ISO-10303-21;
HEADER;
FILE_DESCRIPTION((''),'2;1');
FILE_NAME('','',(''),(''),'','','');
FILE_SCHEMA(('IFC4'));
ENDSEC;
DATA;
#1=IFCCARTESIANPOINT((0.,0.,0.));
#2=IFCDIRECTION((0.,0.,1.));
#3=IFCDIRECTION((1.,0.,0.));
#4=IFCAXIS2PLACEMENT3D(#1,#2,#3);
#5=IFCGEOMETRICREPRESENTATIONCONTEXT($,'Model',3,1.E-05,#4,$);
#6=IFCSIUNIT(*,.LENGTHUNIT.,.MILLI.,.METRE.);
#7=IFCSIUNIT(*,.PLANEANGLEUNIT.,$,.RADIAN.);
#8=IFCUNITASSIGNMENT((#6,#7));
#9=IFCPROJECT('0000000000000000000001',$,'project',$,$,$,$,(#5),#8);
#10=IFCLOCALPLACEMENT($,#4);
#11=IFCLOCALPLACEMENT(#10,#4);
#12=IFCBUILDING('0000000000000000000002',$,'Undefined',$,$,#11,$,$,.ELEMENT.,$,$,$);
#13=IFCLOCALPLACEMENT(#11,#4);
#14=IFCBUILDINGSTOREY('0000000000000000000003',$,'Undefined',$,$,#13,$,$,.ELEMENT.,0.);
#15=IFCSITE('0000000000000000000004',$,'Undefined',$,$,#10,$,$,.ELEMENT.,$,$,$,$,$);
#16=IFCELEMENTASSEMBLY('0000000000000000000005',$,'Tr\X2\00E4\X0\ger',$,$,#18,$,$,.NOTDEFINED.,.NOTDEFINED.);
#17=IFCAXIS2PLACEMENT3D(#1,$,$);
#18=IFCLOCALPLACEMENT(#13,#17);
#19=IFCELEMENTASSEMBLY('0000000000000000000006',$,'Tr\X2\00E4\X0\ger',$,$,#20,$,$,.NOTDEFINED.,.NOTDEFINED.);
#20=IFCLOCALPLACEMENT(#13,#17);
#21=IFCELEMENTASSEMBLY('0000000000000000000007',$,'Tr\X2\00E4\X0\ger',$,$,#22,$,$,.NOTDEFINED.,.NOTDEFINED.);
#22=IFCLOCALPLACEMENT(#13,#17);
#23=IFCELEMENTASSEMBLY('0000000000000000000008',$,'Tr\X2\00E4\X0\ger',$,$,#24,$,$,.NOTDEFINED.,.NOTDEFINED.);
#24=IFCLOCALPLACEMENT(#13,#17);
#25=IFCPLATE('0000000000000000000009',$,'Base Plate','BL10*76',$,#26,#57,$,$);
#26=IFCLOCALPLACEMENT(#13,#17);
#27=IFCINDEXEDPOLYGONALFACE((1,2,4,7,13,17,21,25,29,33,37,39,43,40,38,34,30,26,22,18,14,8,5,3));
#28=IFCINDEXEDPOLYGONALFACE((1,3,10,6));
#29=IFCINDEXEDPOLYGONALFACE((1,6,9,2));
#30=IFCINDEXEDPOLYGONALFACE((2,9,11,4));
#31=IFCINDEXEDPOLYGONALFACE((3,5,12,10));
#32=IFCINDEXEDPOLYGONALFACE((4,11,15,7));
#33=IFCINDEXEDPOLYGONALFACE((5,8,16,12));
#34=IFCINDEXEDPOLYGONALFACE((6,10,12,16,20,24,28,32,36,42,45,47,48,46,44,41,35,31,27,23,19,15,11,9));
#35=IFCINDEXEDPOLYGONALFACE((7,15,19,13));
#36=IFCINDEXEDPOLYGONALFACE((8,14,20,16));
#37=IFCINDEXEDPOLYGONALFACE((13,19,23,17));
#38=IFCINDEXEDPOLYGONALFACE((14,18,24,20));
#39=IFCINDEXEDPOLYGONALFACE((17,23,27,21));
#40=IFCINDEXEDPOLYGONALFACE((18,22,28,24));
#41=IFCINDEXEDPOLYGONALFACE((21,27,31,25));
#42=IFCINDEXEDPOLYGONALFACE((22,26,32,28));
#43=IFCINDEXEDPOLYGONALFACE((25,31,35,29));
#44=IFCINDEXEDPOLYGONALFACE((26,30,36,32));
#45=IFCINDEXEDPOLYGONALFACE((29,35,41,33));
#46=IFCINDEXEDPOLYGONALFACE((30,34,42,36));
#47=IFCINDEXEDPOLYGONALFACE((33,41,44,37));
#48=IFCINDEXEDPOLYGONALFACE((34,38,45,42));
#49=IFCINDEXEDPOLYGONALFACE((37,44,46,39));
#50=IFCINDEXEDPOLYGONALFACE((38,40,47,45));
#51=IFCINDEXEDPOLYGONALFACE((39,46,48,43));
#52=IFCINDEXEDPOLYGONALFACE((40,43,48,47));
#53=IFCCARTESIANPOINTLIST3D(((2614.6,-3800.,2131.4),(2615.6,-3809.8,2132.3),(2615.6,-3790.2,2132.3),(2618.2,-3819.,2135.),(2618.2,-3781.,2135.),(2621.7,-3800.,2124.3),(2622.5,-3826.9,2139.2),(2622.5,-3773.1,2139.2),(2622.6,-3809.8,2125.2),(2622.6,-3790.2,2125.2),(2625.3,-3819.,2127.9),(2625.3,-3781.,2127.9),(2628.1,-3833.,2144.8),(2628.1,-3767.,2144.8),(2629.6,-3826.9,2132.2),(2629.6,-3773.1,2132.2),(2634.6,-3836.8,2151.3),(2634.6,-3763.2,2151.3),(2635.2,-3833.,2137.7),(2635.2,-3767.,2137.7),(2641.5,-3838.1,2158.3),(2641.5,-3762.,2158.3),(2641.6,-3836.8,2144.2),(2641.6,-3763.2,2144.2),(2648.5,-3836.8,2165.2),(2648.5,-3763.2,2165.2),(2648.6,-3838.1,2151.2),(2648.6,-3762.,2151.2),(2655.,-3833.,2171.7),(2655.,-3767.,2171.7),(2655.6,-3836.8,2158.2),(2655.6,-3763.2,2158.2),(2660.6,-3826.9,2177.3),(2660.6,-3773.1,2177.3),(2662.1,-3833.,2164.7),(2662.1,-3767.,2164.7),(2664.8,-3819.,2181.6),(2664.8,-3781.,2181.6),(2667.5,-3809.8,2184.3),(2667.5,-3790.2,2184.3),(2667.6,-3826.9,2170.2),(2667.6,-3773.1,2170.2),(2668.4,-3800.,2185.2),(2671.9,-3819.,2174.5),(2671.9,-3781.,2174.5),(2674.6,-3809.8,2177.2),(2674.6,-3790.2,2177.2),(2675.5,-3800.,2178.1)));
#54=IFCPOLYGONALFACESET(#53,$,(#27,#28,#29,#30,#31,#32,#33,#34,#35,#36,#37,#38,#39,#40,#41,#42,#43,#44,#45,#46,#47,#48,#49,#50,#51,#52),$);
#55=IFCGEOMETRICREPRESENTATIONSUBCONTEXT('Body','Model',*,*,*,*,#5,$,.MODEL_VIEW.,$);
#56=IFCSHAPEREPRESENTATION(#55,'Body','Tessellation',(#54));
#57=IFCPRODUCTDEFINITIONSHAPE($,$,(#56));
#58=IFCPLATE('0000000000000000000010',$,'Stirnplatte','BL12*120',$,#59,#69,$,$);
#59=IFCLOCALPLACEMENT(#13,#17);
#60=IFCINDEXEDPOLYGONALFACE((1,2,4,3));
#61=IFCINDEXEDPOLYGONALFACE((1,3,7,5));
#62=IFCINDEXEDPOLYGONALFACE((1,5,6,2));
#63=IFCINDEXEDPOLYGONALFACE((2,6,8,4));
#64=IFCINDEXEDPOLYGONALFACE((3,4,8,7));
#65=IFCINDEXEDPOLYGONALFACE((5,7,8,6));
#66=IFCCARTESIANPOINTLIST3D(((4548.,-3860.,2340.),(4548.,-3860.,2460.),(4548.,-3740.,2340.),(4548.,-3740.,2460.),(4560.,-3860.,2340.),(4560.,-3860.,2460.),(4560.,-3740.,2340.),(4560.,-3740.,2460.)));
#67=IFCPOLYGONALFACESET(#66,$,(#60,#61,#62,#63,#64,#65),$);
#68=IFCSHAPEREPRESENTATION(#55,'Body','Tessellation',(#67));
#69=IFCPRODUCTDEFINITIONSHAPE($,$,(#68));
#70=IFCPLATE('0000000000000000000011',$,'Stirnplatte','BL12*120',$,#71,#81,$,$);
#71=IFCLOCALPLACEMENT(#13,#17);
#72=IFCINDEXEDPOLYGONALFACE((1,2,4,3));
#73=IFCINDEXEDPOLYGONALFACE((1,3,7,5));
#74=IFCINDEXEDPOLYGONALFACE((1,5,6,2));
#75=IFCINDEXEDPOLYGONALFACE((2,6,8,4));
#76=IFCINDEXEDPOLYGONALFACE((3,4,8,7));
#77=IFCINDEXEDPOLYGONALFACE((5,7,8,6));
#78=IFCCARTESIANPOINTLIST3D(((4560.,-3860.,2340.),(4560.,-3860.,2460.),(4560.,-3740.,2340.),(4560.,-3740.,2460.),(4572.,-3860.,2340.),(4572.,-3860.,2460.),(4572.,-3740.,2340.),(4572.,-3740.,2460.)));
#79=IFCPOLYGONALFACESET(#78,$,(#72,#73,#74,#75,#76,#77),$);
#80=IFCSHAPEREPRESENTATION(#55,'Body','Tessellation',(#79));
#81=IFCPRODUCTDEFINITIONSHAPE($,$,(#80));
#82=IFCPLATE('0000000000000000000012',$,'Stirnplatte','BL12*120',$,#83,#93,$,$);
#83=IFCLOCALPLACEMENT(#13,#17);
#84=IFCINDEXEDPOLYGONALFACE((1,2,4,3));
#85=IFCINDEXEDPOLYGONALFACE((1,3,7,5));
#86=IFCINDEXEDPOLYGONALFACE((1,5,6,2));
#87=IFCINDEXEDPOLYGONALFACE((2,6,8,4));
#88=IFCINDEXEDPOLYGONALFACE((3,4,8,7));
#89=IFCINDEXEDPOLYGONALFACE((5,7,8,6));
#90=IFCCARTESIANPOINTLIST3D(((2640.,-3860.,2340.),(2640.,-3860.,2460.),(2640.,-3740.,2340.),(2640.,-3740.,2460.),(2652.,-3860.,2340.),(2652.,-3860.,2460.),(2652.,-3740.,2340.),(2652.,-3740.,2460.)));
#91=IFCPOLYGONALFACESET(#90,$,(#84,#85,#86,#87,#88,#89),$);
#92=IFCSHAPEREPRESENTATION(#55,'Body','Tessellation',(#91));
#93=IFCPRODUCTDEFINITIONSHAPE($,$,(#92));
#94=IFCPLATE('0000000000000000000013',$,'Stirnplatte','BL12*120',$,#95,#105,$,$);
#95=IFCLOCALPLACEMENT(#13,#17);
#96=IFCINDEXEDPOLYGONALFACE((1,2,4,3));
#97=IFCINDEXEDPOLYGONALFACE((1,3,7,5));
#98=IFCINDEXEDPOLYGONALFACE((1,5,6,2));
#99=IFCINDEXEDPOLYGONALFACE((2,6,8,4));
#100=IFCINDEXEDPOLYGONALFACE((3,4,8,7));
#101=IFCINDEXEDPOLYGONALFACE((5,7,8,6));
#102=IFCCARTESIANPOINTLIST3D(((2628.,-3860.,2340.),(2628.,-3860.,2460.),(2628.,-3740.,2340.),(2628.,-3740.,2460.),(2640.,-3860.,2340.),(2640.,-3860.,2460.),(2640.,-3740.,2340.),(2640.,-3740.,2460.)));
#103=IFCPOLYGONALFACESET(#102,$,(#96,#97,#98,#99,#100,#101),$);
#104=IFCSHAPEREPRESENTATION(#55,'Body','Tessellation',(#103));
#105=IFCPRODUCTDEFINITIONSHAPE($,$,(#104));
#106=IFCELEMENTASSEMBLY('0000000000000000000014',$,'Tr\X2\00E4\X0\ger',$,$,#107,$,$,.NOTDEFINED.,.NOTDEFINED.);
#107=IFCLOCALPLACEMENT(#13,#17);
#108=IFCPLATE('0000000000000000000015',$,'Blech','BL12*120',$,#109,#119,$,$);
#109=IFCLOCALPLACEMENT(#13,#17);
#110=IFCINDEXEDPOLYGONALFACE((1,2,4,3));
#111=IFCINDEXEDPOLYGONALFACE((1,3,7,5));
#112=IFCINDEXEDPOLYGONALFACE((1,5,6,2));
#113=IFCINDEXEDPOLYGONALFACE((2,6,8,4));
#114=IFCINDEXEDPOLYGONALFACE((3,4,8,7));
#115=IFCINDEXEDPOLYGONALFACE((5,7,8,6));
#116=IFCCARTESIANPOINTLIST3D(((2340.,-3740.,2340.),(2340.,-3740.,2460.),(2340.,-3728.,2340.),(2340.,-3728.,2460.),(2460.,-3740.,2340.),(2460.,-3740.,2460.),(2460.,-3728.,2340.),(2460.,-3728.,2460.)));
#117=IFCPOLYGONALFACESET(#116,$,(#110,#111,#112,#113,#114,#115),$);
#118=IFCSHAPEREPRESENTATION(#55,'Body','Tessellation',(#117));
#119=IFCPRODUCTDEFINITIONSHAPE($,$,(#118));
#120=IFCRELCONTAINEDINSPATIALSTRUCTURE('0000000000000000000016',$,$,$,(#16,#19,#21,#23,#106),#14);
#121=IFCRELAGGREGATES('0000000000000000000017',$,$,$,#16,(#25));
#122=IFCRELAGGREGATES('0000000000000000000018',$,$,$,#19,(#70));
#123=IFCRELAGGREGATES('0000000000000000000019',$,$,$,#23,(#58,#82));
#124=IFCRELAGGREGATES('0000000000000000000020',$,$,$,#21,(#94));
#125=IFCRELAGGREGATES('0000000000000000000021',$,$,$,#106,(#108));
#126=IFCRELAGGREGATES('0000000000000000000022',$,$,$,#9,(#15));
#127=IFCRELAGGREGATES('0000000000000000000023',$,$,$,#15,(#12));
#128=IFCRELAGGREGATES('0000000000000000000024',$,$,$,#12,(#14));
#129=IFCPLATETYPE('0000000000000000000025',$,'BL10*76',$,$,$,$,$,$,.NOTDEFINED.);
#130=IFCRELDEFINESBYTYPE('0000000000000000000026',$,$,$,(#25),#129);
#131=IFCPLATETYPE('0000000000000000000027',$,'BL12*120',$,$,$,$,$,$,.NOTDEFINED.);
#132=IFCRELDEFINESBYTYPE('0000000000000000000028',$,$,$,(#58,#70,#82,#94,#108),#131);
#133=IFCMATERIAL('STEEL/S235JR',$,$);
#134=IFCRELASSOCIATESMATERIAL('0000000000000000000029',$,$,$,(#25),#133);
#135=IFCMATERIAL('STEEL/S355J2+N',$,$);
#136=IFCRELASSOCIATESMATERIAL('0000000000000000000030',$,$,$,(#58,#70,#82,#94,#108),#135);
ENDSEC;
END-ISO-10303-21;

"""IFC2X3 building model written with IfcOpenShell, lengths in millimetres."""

from ifc_helpers import new_model, si_unit, frame, frame_2d, origin_with_axes, place, context, subcontext, project, spatial, polyline, circle_curve, parameter, trimmed, segment, composite_curve, outline, extrude, material, type_object, element, aggregate, save


model = new_model("IFC2X3")

# Units and contexts
model_context = context("Model", 3, precision=1e-05, world=origin_with_axes())
body_context = subcontext(model_context, "Body", "Model", "MODEL_VIEW")
ifc_project = project(units=[si_unit("LENGTHUNIT", "METRE", prefix="MILLI"), si_unit("PLANEANGLEUNIT", "RADIAN")], contexts=[model_context])

# Site, building, storey
site_placement = place(None, origin_with_axes())
site = spatial("IfcSite", under=ifc_project, at=site_placement, Name="Undefined", CompositionType="ELEMENT")
building_placement = place(site_placement, origin_with_axes())
building = spatial("IfcBuilding", under=site, at=building_placement, Name="Undefined", CompositionType="ELEMENT")
storey_placement = place(building_placement, origin_with_axes())
storey = spatial("IfcBuildingStorey", under=building, at=storey_placement, Name="Undefined", CompositionType="ELEMENT", Elevation=0.0)

# Shared definitions
ifc_material_1 = material(Name="STEEL/S235JR")

# Element assemblies
assembly_1_placement = place(storey_placement, origin_with_axes())
assembly_1 = element("IfcElementAssembly", 1, at=assembly_1_placement, inside=storey, Name="Träger", AssemblyPlace="NOTDEFINED", PredefinedType="NOTDEFINED")
assembly_2_placement = place(storey_placement, origin_with_axes())
assembly_2 = element("IfcElementAssembly", 2, at=assembly_2_placement, inside=storey, Name="Träger", AssemblyPlace="NOTDEFINED", PredefinedType="NOTDEFINED")
assembly_3_placement = place(storey_placement, origin_with_axes())
assembly_3 = element("IfcElementAssembly", 3, at=assembly_3_placement, inside=storey, Name="Träger", AssemblyPlace="NOTDEFINED", PredefinedType="NOTDEFINED")

# Element assembly
assembly_4_placement = place(storey_placement, origin_with_axes())
assembly_4 = element("IfcElementAssembly", 4, at=assembly_4_placement, inside=storey, Name="Träger", AssemblyPlace="NOTDEFINED", PredefinedType="NOTDEFINED")

# Plates
plate_type_1 = type_object("IfcPlateType", Name="BL10*76", PredefinedType="NOTDEFINED")
plate_1_placement = place(assembly_1_placement, frame((2672.0, -3838.1, 2181.6), z_axis=(0.707141, 0.0, -0.707072), x_axis=(-0.707072, 0.0, -0.707141)))
plate_1 = element("IfcPlate", 5, at=plate_1_placement, type_object=plate_type_1, material=ifc_material_1, Name="Base Plate", Description="BL10*76", context=body_context, shape_type="SweptSolid", body=[
    extrude(outline(composite_curve([segment(trimmed(circle_curve(frame_2d((38.0, 38.0), x_axis=(-1.0, 0.0)), 38.0), [parameter(0.0)], [parameter(1.570796)], True, "PARAMETER"), True, "CONTINUOUS"), segment(trimmed(circle_curve(frame_2d((38.0, 38.0), x_axis=(0.0, -1.0)), 38.0), [parameter(0.0)], [parameter(1.570796)], True, "PARAMETER"), True, "CONTINUOUS"), segment(trimmed(circle_curve(frame_2d((38.0, 38.0), x_axis=(1.0, 0.0)), 38.0), [parameter(0.0)], [parameter(1.570796)], True, "PARAMETER"), True, "CONTINUOUS"), segment(trimmed(circle_curve(frame_2d((38.0, 38.0), x_axis=(0.0, 1.0)), 38.0), [parameter(0.0)], [parameter(1.570796)], True, "PARAMETER"), True, "CONTINUOUS")], self_intersect=True)), frame((0.0, 0.0, -5.0), z_axis=(0.0, 0.0, 1.0), x_axis=(1.0, 0.0, 0.0)), (0.0, 0.0, 1.0), 10.0),
])
aggregate(assembly_1, [plate_1])
ifc_material_2 = material(Name="STEEL/S355J2+N")
plate_type_2 = type_object("IfcPlateType", Name="BL12*120", PredefinedType="NOTDEFINED")
plate_2_placement = place(assembly_4_placement, frame((4554.0, -3800.0, 2340.0), z_axis=(-1.0, 0.0, 0.0), x_axis=(0.0, 0.0, 1.0)))
plate_2 = element("IfcPlate", 6, at=plate_2_placement, type_object=plate_type_2, material=ifc_material_2, Name="Stirnplatte", Description="BL12*120", context=body_context, shape_type="SweptSolid", body=[
    extrude(outline(polyline([(0.0, -60.0), (0.0, 60.0), (120.0, 60.0), (120.0, -60.0), (0.0, -60.0)])), frame((0.0, 0.0, -6.0), z_axis=(0.0, 0.0, 1.0), x_axis=(1.0, 0.0, 0.0)), (0.0, 0.0, 1.0), 12.0),
])
plate_3_placement = place(assembly_2_placement, frame((4566.0, -3800.0, 2340.0), z_axis=(-1.0, 0.0, 0.0), x_axis=(0.0, 0.0, 1.0)))
plate_3 = element("IfcPlate", 7, at=plate_3_placement, type_object=plate_type_2, material=ifc_material_2, Name="Stirnplatte", Description="BL12*120", context=body_context, shape_type="SweptSolid", body=[
    extrude(outline(polyline([(0.0, -60.0), (0.0, 60.0), (120.0, 60.0), (120.0, -60.0), (0.0, -60.0)])), frame((0.0, 0.0, -6.0), z_axis=(0.0, 0.0, 1.0), x_axis=(1.0, 0.0, 0.0)), (0.0, 0.0, 1.0), 12.0),
])
aggregate(assembly_2, [plate_3])
plate_4_placement = place(assembly_4_placement, frame((2646.0, -3800.0, 2340.0), z_axis=(1.0, 0.0, 0.0), x_axis=(0.0, 0.0, 1.0)))
plate_4 = element("IfcPlate", 8, at=plate_4_placement, type_object=plate_type_2, material=ifc_material_2, Name="Stirnplatte", Description="BL12*120", context=body_context, shape_type="SweptSolid", body=[
    extrude(outline(polyline([(0.0, -60.0), (0.0, 60.0), (120.0, 60.0), (120.0, -60.0), (0.0, -60.0)])), frame((0.0, 0.0, -6.0), z_axis=(0.0, 0.0, 1.0), x_axis=(1.0, 0.0, 0.0)), (0.0, 0.0, 1.0), 12.0),
])
aggregate(assembly_4, [plate_2, plate_4])
plate_5_placement = place(assembly_3_placement, frame((2634.0, -3800.0, 2340.0), z_axis=(1.0, 0.0, 0.0), x_axis=(0.0, 0.0, 1.0)))
plate_5 = element("IfcPlate", 9, at=plate_5_placement, type_object=plate_type_2, material=ifc_material_2, Name="Stirnplatte", Description="BL12*120", context=body_context, shape_type="SweptSolid", body=[
    extrude(outline(polyline([(0.0, -60.0), (0.0, 60.0), (120.0, 60.0), (120.0, -60.0), (0.0, -60.0)])), frame((0.0, 0.0, -6.0), z_axis=(0.0, 0.0, 1.0), x_axis=(1.0, 0.0, 0.0)), (0.0, 0.0, 1.0), 12.0),
])
aggregate(assembly_3, [plate_5])

# Element assembly, plate
assembly_5_placement = place(storey_placement, origin_with_axes())
assembly_5 = element("IfcElementAssembly", 10, at=assembly_5_placement, inside=storey, Name="Träger", AssemblyPlace="NOTDEFINED", PredefinedType="NOTDEFINED")
plate_6_placement = place(assembly_5_placement, frame((2400.0, -3734.0, 2340.0), z_axis=(0.0, 1.0, 0.0), x_axis=(0.0, 0.0, 1.0)))
plate_6 = element("IfcPlate", 11, at=plate_6_placement, type_object=plate_type_2, material=ifc_material_2, Name="Blech", Description="BL12*120", context=body_context, shape_type="SweptSolid", body=[
    extrude(outline(polyline([(0.0, -60.0), (0.0, 60.0), (120.0, 60.0), (120.0, -60.0), (0.0, -60.0)])), frame((0.0, 0.0, -6.0), z_axis=(0.0, 0.0, 1.0), x_axis=(1.0, 0.0, 0.0)), (0.0, 0.0, 1.0), 12.0),
])
aggregate(assembly_5, [plate_6])

save(model, "model.ifc")
